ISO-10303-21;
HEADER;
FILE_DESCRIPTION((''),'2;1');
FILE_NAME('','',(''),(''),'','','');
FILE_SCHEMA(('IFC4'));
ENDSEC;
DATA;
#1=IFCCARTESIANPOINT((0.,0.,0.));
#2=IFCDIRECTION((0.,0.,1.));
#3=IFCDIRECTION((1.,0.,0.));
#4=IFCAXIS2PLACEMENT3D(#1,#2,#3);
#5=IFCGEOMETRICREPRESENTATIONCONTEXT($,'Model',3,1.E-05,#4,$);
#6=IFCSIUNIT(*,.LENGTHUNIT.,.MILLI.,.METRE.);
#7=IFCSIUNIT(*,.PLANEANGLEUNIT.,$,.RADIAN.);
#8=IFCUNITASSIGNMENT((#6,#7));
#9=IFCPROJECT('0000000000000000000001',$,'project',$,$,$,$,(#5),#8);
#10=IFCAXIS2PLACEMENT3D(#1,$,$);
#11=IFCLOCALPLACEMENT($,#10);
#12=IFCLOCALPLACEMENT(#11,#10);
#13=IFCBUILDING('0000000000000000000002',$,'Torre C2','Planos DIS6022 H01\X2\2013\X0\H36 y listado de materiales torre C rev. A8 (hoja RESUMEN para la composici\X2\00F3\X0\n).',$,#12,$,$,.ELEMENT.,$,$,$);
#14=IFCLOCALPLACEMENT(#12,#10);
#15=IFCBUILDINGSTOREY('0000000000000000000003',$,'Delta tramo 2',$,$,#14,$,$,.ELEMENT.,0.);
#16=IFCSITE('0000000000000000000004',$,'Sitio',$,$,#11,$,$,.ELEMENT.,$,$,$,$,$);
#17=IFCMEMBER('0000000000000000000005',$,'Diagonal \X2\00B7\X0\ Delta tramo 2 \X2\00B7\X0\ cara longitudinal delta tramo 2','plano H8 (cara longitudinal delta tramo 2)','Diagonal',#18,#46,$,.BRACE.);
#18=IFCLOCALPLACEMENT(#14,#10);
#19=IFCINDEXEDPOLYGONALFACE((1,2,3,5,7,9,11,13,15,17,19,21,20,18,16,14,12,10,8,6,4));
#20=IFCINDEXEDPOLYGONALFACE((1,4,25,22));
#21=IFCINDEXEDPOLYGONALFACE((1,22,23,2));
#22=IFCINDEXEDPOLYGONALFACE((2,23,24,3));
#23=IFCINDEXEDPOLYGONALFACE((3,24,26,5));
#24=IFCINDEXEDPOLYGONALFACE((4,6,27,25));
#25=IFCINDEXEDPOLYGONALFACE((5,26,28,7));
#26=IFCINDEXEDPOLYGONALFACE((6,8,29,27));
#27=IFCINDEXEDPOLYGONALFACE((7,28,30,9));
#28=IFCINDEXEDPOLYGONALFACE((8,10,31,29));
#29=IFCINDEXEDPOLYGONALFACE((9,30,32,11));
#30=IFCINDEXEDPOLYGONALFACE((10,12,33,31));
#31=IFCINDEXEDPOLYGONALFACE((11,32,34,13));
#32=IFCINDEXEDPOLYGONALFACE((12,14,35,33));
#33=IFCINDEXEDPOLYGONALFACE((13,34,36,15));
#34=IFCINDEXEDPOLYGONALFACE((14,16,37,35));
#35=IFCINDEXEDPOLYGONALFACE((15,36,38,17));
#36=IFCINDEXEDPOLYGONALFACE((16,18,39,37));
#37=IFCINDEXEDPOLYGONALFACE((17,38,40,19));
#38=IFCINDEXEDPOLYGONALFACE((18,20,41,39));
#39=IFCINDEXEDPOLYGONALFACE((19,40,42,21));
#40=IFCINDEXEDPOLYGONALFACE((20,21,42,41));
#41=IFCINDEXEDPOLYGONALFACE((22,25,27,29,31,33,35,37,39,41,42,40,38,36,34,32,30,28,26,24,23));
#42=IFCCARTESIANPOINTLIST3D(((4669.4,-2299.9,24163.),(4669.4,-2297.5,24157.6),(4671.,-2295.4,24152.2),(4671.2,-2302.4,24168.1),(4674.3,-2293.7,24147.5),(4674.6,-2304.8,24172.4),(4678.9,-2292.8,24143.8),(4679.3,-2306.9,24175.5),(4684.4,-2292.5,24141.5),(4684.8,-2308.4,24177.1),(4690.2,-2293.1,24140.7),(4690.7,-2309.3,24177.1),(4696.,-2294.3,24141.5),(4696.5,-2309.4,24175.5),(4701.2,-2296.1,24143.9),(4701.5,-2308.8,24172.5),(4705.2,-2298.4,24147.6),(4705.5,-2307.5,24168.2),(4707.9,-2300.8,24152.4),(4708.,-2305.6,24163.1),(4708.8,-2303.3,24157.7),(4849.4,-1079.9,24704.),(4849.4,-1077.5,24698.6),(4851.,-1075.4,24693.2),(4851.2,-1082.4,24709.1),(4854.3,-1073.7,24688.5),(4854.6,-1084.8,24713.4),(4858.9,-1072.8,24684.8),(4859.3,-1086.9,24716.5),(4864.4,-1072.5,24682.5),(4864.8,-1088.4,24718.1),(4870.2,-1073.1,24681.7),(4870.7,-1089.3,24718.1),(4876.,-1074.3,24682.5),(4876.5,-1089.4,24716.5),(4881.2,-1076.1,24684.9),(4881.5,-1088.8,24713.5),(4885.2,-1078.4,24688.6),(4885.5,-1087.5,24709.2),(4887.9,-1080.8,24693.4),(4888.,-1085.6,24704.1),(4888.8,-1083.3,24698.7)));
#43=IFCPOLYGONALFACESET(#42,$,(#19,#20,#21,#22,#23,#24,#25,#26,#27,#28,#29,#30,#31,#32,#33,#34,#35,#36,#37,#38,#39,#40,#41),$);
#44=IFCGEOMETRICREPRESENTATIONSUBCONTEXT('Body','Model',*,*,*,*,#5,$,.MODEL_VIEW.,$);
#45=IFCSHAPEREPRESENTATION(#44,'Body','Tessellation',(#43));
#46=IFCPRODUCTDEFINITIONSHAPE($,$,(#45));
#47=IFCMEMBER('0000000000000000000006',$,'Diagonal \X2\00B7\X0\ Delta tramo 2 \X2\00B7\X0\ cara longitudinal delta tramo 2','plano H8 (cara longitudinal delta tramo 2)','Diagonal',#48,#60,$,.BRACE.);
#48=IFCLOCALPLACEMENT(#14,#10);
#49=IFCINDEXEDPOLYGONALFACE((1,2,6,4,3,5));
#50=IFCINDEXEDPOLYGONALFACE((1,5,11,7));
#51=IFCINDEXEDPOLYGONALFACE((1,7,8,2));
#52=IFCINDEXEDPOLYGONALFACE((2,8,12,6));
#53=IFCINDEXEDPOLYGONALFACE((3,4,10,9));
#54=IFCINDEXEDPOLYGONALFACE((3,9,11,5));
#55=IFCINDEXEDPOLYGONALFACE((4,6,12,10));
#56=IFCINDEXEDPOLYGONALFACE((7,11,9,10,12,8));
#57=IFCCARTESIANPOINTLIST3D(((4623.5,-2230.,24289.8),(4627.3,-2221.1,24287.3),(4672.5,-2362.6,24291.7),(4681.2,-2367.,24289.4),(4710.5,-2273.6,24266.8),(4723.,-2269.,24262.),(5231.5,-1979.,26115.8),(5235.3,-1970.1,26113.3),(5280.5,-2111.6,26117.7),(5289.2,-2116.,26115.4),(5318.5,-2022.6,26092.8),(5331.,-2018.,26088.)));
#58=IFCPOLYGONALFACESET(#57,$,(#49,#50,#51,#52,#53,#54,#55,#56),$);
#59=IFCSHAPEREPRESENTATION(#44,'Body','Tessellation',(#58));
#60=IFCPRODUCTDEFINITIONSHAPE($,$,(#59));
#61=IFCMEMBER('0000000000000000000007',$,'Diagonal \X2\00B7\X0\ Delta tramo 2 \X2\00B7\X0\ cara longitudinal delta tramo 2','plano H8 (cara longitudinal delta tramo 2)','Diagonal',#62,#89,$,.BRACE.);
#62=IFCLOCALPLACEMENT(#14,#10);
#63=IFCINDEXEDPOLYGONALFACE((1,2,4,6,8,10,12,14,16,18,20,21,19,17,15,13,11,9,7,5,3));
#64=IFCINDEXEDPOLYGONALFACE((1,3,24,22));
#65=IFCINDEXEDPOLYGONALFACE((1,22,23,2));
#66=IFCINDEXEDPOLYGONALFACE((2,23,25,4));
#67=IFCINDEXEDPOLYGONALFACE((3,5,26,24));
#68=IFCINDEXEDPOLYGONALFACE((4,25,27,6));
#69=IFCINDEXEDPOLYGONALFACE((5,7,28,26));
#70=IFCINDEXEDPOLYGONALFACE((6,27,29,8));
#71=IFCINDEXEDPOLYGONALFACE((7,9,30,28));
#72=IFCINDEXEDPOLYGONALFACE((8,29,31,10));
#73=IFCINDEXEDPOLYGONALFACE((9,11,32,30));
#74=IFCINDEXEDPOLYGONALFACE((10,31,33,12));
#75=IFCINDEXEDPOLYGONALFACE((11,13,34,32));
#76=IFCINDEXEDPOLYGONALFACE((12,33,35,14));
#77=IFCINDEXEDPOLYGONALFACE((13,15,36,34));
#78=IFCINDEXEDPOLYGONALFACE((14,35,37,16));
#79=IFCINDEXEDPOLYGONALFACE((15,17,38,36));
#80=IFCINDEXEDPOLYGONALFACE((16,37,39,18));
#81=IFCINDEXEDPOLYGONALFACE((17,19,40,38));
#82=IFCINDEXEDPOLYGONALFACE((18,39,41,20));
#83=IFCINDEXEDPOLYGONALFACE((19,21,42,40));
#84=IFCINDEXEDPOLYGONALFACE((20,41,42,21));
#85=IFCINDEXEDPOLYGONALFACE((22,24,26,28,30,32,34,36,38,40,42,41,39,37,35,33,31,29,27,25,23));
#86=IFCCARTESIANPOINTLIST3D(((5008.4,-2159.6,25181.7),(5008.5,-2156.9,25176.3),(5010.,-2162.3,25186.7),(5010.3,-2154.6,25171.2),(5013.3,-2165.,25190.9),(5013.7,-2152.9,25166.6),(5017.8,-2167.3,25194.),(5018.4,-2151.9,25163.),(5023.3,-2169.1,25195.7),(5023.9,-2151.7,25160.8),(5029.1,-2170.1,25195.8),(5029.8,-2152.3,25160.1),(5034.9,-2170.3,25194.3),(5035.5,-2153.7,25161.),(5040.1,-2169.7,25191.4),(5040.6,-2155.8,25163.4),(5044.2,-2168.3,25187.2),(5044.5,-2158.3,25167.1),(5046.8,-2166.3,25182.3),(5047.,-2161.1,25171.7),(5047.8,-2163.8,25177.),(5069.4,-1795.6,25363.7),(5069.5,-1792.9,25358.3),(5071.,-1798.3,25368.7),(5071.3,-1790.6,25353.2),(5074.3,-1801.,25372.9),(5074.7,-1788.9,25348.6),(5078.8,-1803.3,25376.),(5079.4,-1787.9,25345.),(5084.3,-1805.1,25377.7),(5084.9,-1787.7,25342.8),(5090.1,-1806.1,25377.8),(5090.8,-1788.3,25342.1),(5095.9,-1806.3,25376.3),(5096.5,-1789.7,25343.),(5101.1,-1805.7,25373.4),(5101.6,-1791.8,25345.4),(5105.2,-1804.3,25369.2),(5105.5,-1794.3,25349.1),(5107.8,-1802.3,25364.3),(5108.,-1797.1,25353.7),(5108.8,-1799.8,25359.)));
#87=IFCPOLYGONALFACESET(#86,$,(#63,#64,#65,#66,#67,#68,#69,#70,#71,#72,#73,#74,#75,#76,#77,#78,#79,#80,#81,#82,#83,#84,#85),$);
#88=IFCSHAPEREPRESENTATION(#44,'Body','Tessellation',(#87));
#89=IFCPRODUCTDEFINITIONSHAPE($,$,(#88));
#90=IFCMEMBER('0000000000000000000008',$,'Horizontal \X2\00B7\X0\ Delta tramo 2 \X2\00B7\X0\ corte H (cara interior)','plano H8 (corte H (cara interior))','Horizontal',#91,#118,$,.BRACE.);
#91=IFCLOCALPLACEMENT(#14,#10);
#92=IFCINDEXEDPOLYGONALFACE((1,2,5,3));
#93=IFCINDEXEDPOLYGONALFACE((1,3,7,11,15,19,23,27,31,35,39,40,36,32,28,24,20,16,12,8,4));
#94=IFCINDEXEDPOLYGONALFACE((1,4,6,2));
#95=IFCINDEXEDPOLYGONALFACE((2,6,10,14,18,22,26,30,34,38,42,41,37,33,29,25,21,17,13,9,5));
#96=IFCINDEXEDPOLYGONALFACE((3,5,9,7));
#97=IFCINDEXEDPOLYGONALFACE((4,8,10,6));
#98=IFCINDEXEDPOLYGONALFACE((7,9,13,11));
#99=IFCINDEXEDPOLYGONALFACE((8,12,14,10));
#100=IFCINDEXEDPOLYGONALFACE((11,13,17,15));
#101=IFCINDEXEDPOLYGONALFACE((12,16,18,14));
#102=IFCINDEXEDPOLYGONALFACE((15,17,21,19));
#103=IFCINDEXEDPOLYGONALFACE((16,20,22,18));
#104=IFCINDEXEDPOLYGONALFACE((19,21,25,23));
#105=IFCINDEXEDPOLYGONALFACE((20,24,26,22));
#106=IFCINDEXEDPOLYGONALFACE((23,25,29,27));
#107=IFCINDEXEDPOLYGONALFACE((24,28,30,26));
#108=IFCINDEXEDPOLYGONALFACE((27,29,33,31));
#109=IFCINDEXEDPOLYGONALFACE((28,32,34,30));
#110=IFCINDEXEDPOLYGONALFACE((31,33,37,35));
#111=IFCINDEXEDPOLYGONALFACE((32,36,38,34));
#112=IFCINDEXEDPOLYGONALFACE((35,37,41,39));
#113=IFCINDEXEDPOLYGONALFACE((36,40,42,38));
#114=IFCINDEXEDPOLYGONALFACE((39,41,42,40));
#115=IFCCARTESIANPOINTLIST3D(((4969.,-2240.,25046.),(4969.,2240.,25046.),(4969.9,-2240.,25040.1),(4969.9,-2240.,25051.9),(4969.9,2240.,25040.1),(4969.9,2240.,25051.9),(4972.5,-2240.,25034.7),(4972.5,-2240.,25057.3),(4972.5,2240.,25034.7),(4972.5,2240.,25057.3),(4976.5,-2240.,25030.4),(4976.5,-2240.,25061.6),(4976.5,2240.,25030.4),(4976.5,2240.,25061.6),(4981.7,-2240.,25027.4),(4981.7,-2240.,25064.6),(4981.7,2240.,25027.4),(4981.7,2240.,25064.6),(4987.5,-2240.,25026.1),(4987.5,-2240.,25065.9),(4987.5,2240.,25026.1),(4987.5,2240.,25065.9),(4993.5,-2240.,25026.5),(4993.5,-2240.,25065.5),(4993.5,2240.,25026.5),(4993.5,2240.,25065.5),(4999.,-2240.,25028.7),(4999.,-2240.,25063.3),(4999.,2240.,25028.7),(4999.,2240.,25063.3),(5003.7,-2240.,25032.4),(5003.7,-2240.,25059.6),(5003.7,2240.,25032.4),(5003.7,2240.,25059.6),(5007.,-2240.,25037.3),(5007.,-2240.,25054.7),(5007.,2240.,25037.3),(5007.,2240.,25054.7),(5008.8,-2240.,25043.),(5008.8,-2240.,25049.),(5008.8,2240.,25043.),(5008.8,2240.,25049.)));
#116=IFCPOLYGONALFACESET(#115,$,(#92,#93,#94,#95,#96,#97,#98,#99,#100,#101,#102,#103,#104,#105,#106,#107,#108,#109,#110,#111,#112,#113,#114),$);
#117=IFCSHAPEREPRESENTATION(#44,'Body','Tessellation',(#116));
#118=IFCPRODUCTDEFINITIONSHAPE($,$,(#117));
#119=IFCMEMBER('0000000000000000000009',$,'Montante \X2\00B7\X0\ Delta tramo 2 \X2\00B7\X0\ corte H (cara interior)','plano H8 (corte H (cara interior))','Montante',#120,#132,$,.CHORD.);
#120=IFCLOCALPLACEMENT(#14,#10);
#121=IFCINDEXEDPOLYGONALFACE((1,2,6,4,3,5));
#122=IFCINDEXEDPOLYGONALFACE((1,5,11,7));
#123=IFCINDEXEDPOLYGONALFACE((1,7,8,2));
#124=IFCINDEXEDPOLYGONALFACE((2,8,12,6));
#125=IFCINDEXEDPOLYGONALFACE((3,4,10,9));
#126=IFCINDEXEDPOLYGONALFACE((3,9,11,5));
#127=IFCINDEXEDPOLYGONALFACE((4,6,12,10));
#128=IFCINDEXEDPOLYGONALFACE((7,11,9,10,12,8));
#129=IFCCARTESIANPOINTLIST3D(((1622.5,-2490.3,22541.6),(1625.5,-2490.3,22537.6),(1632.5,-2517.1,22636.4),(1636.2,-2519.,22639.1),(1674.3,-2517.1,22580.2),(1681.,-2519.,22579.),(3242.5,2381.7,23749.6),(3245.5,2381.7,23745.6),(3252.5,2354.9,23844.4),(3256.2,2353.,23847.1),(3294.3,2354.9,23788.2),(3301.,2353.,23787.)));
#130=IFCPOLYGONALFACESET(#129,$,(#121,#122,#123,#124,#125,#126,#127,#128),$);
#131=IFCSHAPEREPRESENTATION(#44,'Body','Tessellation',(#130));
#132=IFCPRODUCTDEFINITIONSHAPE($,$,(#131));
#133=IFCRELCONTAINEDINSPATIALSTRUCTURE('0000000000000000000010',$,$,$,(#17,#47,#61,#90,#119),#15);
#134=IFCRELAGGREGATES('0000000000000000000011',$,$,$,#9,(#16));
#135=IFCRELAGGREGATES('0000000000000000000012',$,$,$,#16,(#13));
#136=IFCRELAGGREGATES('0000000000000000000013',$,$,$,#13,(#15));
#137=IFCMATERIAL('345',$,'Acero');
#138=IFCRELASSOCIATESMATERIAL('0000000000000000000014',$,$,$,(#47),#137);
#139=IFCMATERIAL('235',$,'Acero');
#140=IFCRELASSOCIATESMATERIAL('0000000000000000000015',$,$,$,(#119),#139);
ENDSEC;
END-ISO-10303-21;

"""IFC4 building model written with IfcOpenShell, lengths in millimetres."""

from ifc_helpers import new_model, si_unit, frame, frame_2d, origin, origin_with_axes, place, context, subcontext, project, spatial, circle, l_section, extrude, material, element, save


model = new_model("IFC4")

# Units and contexts
model_context = context("Model", 3, precision=1e-05, world=origin_with_axes())
body_context = subcontext(model_context, "Body", "Model", "MODEL_VIEW")
ifc_project = project(units=[si_unit("LENGTHUNIT", "METRE", prefix="MILLI"), si_unit("PLANEANGLEUNIT", "RADIAN")], contexts=[model_context])

# Site, building, storey
site_placement = place(None, origin())
site = spatial("IfcSite", under=ifc_project, at=site_placement, Name="Sitio", CompositionType="ELEMENT")
building_placement = place(site_placement, origin())
building = spatial("IfcBuilding", under=site, at=building_placement, Name="Torre C2", Description="Planos DIS6022 H01–H36 y listado de materiales torre C rev. A8 (hoja RESUMEN para la composición).", CompositionType="ELEMENT")
storey_placement = place(building_placement, origin())
storey = spatial("IfcBuildingStorey", under=building, at=storey_placement, Name="Delta tramo 2", CompositionType="ELEMENT", Elevation=0.0)

# Members
ifc_material_1 = material(Name="345", Category="Acero")
ifc_material_2 = material(Name="235", Category="Acero")
member_1_placement = place(storey_placement, frame((4689.0, -2301.0, 24159.0), z_axis=(0.133664, 0.905948, 0.401736), x_axis=(-0.981631, 0.176718, -0.071907)))
element("IfcMember", 1, at=member_1_placement, inside=storey, Name="Diagonal · Delta tramo 2 · cara longitudinal delta tramo 2", Description="plano H8 (cara longitudinal delta tramo 2)", ObjectType="Diagonal", PredefinedType="BRACE", context=body_context, shape_type="SweptSolid", body=[
    extrude(circle(Radius=20.0), None, (0.0, 0.0, 1.0), 1346.7),
])
member_2_placement = place(storey_placement, frame((4723.0, -2269.0, 24262.0), z_axis=(0.313263, 0.129324, 0.94082), x_axis=(-0.870378, 0.435386, 0.22996)))
element("IfcMember", 2, at=member_2_placement, inside=storey, material=ifc_material_1, Name="Diagonal · Delta tramo 2 · cara longitudinal delta tramo 2", Description="plano H8 (cara longitudinal delta tramo 2)", ObjectType="Diagonal", PredefinedType="BRACE", context=body_context, shape_type="SweptSolid", body=[
    extrude(l_section(Depth=110.0, Width=110.0, Thickness=10.0, at=frame_2d((55.0, 55.0))), None, (0.0, 0.0, 1.0), 1940.9),
])
member_3_placement = place(storey_placement, frame((5028.0, -2161.0, 25178.0), z_axis=(0.148234, 0.884546, 0.442273), x_axis=(-0.975269, 0.204886, -0.082896)))
element("IfcMember", 3, at=member_3_placement, inside=storey, Name="Diagonal · Delta tramo 2 · cara longitudinal delta tramo 2", Description="plano H8 (cara longitudinal delta tramo 2)", ObjectType="Diagonal", PredefinedType="BRACE", context=body_context, shape_type="SweptSolid", body=[
    extrude(circle(Radius=20.0), None, (0.0, 0.0, 1.0), 411.5),
])
member_4_placement = place(storey_placement, frame((4989.0, -2240.0, 25046.0), z_axis=(0.0, 1.0, 0.0), x_axis=(-1.0, 0.0, 0.0)))
element("IfcMember", 4, at=member_4_placement, inside=storey, Name="Horizontal · Delta tramo 2 · corte H (cara interior)", Description="plano H8 (corte H (cara interior))", ObjectType="Horizontal", PredefinedType="BRACE", context=body_context, shape_type="SweptSolid", body=[
    extrude(circle(Radius=20.0), None, (0.0, 0.0, 1.0), 4480.0),
])
member_5_placement = place(storey_placement, frame((1681.0, -2519.0, 22579.0), z_axis=(0.30714, 0.923694, 0.229028), x_axis=(-0.740489, 0.38313, -0.552167)))
element("IfcMember", 5, at=member_5_placement, inside=storey, material=ifc_material_2, Name="Montante · Delta tramo 2 · corte H (cara interior)", Description="plano H8 (corte H (cara interior))", ObjectType="Montante", PredefinedType="CHORD", context=body_context, shape_type="SweptSolid", body=[
    extrude(l_section(Depth=75.0, Width=75.0, Thickness=5.0, at=frame_2d((37.5, 37.5))), None, (0.0, 0.0, 1.0), 5274.5),
])

save(model, "model.ifc")
